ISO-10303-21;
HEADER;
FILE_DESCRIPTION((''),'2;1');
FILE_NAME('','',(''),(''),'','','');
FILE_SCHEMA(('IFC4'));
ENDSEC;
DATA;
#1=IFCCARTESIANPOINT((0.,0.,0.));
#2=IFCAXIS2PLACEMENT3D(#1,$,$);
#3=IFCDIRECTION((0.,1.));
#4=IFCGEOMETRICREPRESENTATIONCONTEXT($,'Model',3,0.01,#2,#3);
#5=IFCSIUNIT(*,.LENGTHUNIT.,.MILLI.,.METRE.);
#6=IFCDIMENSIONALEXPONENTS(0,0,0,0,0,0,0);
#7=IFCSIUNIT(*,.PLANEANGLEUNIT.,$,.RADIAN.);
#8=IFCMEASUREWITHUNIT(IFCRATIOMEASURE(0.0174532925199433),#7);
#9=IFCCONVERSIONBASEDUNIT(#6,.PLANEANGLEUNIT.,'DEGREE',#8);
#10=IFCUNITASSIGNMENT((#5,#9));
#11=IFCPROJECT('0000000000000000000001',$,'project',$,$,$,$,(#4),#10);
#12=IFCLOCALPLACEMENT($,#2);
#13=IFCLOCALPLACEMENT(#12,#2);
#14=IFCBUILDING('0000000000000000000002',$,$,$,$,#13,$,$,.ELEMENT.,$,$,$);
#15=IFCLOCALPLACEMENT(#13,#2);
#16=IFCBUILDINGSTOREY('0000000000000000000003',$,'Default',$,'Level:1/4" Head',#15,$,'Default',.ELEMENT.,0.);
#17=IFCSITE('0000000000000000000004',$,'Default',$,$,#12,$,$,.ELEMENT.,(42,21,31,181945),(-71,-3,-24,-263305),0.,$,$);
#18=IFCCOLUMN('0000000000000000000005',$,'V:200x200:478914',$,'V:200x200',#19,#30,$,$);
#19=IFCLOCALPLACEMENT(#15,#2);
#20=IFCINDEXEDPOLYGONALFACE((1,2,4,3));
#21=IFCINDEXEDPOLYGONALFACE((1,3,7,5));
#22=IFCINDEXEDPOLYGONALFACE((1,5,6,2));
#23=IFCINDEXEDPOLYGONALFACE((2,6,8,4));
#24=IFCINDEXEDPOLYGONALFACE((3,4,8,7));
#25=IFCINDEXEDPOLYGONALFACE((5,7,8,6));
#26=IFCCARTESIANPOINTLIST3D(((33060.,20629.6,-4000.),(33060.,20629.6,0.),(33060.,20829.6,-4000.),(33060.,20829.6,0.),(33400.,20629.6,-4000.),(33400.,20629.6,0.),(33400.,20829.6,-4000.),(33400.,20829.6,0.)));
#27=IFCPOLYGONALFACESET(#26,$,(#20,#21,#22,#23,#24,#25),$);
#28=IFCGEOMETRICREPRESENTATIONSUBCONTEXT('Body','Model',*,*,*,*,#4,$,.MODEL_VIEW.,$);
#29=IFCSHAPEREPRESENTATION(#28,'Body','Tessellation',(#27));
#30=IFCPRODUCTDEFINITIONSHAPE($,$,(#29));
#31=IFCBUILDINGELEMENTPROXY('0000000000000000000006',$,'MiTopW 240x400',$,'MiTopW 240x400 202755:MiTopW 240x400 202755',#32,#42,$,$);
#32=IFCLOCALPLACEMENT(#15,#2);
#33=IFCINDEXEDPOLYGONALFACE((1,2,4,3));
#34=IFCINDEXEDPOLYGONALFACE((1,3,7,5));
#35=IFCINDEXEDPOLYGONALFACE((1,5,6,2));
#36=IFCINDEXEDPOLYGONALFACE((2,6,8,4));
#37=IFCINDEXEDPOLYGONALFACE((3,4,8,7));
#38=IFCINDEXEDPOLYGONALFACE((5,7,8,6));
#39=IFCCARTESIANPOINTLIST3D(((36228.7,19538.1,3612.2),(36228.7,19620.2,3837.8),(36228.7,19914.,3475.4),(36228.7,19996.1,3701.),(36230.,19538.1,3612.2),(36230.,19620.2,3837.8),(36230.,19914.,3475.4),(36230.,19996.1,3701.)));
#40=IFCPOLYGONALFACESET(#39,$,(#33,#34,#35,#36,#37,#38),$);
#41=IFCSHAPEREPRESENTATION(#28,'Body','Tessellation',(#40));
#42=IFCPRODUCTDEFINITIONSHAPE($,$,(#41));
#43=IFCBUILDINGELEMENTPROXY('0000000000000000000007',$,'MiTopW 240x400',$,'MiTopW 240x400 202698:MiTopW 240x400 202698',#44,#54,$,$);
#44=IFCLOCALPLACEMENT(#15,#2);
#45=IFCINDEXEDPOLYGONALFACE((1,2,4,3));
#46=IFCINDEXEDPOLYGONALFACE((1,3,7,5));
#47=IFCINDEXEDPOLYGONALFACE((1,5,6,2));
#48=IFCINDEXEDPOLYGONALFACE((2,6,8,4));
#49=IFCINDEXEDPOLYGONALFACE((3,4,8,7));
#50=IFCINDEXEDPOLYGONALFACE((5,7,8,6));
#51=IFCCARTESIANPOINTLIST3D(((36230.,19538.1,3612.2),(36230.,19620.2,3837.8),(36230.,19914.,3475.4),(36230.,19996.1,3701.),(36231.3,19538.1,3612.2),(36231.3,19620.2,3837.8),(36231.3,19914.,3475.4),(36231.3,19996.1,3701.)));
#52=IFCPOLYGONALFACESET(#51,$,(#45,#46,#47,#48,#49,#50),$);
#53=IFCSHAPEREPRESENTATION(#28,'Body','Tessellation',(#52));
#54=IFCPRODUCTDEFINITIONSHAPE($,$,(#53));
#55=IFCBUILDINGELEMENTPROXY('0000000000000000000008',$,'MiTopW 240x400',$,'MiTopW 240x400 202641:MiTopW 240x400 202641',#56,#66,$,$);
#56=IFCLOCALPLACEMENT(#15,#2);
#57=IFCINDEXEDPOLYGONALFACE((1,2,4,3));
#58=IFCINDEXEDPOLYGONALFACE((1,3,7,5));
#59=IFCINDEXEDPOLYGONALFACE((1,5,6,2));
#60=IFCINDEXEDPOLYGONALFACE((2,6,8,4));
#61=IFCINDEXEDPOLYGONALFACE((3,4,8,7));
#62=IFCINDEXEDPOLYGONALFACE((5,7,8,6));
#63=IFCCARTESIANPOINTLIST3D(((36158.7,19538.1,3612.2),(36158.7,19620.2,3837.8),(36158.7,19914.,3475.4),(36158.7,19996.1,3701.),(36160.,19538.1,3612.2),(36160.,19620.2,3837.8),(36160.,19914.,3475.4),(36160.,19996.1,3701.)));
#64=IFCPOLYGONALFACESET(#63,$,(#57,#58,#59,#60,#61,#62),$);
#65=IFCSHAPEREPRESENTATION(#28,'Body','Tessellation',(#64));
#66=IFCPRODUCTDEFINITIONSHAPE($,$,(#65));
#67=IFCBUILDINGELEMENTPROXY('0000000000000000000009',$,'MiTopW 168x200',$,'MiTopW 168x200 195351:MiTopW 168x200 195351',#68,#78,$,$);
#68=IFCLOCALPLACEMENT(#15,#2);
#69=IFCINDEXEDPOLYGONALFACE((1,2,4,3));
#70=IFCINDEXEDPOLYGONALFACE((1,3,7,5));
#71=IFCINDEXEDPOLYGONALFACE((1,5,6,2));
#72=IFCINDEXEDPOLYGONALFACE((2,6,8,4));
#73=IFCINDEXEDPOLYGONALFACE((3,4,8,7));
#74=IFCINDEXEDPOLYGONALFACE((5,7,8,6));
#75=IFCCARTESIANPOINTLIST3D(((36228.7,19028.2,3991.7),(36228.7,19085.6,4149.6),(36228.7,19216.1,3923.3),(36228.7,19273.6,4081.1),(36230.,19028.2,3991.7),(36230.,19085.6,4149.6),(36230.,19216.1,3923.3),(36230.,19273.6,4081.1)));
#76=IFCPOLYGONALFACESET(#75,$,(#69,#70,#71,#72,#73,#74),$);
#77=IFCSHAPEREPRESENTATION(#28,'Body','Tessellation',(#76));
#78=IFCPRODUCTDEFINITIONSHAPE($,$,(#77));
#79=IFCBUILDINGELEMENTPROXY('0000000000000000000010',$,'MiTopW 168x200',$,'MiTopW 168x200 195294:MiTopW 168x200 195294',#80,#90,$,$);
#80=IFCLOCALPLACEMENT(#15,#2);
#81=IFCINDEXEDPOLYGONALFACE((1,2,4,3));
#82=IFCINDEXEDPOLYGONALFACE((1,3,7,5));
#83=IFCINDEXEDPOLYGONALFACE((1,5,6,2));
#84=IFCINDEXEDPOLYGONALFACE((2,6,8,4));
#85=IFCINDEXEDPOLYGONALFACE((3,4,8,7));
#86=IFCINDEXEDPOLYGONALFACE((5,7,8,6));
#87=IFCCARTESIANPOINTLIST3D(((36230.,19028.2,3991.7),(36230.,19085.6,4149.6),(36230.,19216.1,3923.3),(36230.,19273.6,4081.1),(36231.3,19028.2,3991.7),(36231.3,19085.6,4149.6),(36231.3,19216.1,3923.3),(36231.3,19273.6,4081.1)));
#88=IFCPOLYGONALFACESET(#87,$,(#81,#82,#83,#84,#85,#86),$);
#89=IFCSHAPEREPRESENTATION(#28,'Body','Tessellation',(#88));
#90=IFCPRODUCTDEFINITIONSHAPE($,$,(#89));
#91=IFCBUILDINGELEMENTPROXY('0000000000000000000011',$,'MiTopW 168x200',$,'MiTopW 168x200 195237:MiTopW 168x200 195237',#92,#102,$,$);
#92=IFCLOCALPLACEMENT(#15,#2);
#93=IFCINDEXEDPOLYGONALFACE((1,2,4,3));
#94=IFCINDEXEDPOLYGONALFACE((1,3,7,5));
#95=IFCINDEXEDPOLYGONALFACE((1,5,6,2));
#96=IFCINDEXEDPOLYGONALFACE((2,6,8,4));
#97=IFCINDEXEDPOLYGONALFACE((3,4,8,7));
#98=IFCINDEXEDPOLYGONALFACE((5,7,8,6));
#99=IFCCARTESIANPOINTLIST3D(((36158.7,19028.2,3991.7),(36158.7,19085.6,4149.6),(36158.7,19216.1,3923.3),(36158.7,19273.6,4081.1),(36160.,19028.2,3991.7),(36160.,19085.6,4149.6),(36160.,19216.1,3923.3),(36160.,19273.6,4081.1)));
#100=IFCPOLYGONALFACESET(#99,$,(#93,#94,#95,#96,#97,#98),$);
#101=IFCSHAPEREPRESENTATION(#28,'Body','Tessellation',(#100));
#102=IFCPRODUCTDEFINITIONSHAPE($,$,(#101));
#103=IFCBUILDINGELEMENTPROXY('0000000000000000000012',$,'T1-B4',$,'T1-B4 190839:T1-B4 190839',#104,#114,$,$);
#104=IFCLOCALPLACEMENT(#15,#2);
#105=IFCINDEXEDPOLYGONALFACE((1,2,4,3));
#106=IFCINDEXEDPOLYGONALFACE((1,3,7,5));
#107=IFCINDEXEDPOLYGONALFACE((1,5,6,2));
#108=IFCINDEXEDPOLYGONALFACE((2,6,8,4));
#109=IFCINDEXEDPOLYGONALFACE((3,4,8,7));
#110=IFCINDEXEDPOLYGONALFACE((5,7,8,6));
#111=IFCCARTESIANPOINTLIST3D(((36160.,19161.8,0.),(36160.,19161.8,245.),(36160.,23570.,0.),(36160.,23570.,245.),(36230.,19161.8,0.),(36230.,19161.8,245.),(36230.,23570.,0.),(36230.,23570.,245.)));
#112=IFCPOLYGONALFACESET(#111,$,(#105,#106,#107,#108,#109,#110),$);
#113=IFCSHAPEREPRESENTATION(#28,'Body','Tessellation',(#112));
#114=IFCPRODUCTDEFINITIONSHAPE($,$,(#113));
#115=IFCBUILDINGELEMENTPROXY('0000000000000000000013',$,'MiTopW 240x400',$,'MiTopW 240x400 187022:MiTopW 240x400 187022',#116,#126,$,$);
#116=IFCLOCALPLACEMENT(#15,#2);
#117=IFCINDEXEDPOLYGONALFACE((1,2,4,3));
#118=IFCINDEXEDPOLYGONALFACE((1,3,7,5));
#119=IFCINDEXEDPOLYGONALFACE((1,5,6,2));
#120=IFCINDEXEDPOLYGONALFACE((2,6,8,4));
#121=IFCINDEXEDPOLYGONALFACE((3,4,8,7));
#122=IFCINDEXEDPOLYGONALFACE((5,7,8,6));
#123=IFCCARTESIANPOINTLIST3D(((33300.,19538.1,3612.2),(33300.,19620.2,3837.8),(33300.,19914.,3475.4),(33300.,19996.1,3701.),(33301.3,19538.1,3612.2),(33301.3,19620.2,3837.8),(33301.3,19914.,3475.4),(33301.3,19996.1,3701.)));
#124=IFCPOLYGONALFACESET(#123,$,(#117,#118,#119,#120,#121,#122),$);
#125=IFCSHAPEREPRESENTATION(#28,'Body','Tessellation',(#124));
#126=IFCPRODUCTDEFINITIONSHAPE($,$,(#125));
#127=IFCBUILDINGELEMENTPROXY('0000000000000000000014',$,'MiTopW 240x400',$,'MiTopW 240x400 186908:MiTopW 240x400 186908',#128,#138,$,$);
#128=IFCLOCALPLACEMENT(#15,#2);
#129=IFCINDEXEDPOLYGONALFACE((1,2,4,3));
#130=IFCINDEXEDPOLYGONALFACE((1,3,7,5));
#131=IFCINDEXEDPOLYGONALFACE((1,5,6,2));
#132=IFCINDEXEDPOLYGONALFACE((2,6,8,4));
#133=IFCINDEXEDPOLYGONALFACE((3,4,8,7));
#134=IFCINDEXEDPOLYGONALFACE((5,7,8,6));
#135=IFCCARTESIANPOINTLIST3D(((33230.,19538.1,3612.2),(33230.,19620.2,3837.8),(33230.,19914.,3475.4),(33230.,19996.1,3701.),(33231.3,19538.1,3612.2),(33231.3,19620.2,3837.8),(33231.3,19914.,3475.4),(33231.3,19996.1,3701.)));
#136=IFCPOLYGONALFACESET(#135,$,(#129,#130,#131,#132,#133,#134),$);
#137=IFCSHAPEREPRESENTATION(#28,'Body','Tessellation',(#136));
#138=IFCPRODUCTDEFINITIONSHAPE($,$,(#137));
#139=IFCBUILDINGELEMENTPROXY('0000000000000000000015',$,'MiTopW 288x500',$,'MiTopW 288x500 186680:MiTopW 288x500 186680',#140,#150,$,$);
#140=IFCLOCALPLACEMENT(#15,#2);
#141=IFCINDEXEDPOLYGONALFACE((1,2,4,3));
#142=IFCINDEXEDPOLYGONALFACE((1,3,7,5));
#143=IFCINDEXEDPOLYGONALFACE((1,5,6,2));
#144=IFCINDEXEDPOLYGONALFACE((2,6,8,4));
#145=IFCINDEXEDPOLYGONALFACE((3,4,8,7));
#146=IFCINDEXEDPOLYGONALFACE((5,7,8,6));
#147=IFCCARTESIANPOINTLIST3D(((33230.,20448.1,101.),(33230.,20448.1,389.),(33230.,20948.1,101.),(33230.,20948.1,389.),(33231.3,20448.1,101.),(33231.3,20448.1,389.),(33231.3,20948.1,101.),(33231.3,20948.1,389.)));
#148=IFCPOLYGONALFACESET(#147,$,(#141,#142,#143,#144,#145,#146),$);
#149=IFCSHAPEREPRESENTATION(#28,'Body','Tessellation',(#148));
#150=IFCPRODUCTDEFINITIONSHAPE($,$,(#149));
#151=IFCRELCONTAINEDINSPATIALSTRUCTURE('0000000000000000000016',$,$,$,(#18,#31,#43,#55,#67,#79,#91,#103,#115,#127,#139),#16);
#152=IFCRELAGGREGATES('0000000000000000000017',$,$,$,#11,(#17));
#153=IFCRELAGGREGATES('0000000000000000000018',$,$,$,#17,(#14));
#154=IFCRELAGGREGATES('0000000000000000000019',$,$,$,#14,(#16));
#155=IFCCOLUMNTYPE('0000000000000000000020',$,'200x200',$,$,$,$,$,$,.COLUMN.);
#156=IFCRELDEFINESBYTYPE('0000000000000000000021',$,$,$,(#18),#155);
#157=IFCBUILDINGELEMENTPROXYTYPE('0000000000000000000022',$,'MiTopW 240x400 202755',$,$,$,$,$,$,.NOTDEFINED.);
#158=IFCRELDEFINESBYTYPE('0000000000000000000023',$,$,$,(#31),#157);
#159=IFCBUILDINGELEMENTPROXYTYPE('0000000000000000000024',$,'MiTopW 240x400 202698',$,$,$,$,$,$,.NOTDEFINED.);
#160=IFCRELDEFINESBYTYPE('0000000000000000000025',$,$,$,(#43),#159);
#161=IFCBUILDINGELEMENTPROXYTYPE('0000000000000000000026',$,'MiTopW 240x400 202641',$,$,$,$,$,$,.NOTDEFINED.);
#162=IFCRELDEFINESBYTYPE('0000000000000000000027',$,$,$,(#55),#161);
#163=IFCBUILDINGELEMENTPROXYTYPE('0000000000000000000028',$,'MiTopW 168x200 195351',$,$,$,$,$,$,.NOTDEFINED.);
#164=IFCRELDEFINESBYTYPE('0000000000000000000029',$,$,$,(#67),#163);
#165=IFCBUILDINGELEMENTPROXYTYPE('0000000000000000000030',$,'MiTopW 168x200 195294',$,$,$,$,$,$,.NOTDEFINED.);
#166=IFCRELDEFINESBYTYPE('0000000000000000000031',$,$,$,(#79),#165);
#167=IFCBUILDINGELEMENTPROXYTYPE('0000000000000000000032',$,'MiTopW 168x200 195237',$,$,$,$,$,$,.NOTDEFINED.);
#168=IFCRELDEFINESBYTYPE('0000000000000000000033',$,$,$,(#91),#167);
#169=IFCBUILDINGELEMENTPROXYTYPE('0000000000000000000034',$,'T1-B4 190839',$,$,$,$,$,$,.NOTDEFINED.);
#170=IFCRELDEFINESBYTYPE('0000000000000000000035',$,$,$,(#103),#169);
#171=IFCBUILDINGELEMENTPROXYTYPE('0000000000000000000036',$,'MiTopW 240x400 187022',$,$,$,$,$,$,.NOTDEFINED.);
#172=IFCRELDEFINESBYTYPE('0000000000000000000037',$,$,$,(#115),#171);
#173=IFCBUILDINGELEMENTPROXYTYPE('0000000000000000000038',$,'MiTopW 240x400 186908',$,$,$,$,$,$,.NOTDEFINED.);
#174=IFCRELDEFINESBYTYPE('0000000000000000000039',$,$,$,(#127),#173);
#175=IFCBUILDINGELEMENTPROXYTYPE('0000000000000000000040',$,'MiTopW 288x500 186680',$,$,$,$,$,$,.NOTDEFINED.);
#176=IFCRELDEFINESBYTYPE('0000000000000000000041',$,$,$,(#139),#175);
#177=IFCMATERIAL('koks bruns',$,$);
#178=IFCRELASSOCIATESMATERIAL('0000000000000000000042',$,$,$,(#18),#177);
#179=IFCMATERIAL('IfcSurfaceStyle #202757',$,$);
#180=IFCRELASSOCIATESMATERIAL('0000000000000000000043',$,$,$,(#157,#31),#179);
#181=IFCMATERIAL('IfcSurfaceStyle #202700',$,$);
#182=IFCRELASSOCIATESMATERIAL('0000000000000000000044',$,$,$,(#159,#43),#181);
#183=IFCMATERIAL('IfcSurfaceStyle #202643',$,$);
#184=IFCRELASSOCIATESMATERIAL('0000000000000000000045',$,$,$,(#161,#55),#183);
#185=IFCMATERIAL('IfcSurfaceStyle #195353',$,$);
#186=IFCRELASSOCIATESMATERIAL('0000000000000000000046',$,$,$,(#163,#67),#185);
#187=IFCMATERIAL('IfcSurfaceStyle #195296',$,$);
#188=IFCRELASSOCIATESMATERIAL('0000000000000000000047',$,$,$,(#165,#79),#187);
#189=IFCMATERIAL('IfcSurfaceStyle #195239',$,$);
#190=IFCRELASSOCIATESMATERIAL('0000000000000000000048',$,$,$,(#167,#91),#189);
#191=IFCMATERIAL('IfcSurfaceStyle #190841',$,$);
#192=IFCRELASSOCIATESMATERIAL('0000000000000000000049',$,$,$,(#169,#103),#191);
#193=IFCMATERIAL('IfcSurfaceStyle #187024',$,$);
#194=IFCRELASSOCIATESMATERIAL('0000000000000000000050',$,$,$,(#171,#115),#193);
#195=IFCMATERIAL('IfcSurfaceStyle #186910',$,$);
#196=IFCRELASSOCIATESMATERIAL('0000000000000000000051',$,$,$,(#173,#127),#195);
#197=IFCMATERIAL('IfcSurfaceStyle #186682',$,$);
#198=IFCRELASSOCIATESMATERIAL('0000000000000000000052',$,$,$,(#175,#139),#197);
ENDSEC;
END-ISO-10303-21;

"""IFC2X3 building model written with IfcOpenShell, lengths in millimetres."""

from ifc_helpers import new_model, entity, si_unit, converted_unit, direction, frame, origin, origin_2d_with_axis, place, context, subcontext, project, spatial, polyline, rectangle, outline, extrude, source, transform, mapped, material, type_object, type_shapes, element, save


model = new_model("IFC2X3")

# Units and contexts
model_context = context("Model", 3, precision=0.01, world=origin(), true_north=direction((0.0, 1.0)))
body_context = subcontext(model_context, "Body", "Model", "MODEL_VIEW")
ifc_project = project(units=[si_unit("LENGTHUNIT", "METRE", prefix="MILLI"), converted_unit("PLANEANGLEUNIT", "DEGREE", entity("IfcRatioMeasure", 0.0174532925199433), si_unit("PLANEANGLEUNIT", "RADIAN"), dimensions=[0, 0, 0, 0, 0, 0, 0])], contexts=[model_context])

# Site, building, storey
site_placement = place(None, origin())
site = spatial("IfcSite", under=ifc_project, at=site_placement, Name="Default", CompositionType="ELEMENT", RefLatitude=(42, 21, 31, 181945), RefLongitude=(-71, -3, -24, -263305), RefElevation=0.0)
building_placement = place(site_placement, origin())
building = spatial("IfcBuilding", under=site, at=building_placement, CompositionType="ELEMENT")
storey_placement = place(building_placement, origin())
storey = spatial("IfcBuildingStorey", under=building, at=storey_placement, Name="Default", ObjectType="Level:1/4\" Head", LongName="Default", CompositionType="ELEMENT", Elevation=0.0)

# Column
ifc_material_1 = material(Name="koks bruns")
column_type_1 = type_object("IfcColumnType", Name="200x200", PredefinedType="COLUMN")
shared_shape_1 = source(origin(), body_context, "Body", "SweptSolid", [
    extrude(rectangle(XDim=340.0, YDim=200.0, at=origin_2d_with_axis()), frame((100.0, 280.0, -4000.0), z_axis=(0.0, 0.0, 1.0), x_axis=(0.0, -1.0, 0.0)), (0.0, 0.0, 1.0), 4000.0),
])
type_shapes(column_type_1, [shared_shape_1])
column_placement = place(storey_placement, frame((33510.0, 20629.6, 0.0), z_axis=(0.0, 0.0, 1.0), x_axis=(0.0, 1.0, 0.0)))
element("IfcColumn", 1, at=column_placement, inside=storey, type_object=column_type_1, material=ifc_material_1, Name="V:200x200:478914", ObjectType="V:200x200", context=body_context, shape_type="MappedRepresentation", body=[
    mapped(shared_shape_1, transform((0.0, 0.0, 0.0), scale=1.0)),
])

# Building element proxies
ifc_material_2 = material(Name="IfcSurfaceStyle #202757")
building_element_proxy_type_1 = type_object("IfcBuildingElementProxyType", Name="MiTopW 240x400 202755", PredefinedType="NOTDEFINED", material=ifc_material_2)
shared_shape_2 = source(origin(), body_context, "Body", "SweptSolid", [
    extrude(outline(polyline([(-200.0, -120.0), (200.0, -120.0), (200.0, 120.0), (-200.0, 120.0), (-200.0, -120.0)])), frame((200.0, 120.0, 0.0), z_axis=(0.0, 0.0, 1.0), x_axis=(-1.0, 0.0, 0.0)), (0.0, 0.0, 1.0), 1.3),
])
type_shapes(building_element_proxy_type_1, [shared_shape_2])
proxy_1_placement = place(building_placement, frame((36230.0, 19620.2, 3837.8), z_axis=(-1.0, 0.0, 0.0), x_axis=(0.0, 0.939693, -0.34202)))
element("IfcBuildingElementProxy", 2, at=proxy_1_placement, inside=storey, type_object=building_element_proxy_type_1, material=ifc_material_2, Name="MiTopW 240x400", ObjectType="MiTopW 240x400 202755:MiTopW 240x400 202755", context=body_context, shape_type="MappedRepresentation", body=[
    mapped(shared_shape_2, transform((0.0, 0.0, 0.0), scale=1.0)),
])
ifc_material_3 = material(Name="IfcSurfaceStyle #202700")
building_element_proxy_type_2 = type_object("IfcBuildingElementProxyType", Name="MiTopW 240x400 202698", PredefinedType="NOTDEFINED", material=ifc_material_3)
shared_shape_3 = source(origin(), body_context, "Body", "SweptSolid", [
    extrude(outline(polyline([(-200.0, -120.0), (200.0, -120.0), (200.0, 120.0), (-200.0, 120.0), (-200.0, -120.0)])), frame((200.0, 120.0, 0.0), z_axis=(0.0, 0.0, 1.0), x_axis=(-1.0, 0.0, 0.0)), (0.0, 0.0, 1.0), 1.3),
])
type_shapes(building_element_proxy_type_2, [shared_shape_3])
proxy_2_placement = place(building_placement, frame((36231.3, 19620.2, 3837.8), z_axis=(-1.0, 0.0, 0.0), x_axis=(0.0, 0.939693, -0.34202)))
element("IfcBuildingElementProxy", 3, at=proxy_2_placement, inside=storey, type_object=building_element_proxy_type_2, material=ifc_material_3, Name="MiTopW 240x400", ObjectType="MiTopW 240x400 202698:MiTopW 240x400 202698", context=body_context, shape_type="MappedRepresentation", body=[
    mapped(shared_shape_3, transform((0.0, 0.0, 0.0), scale=1.0)),
])
ifc_material_4 = material(Name="IfcSurfaceStyle #202643")
building_element_proxy_type_3 = type_object("IfcBuildingElementProxyType", Name="MiTopW 240x400 202641", PredefinedType="NOTDEFINED", material=ifc_material_4)
shared_shape_4 = source(origin(), body_context, "Body", "SweptSolid", [
    extrude(outline(polyline([(-200.0, -120.0), (200.0, -120.0), (200.0, 120.0), (-200.0, 120.0), (-200.0, -120.0)])), frame((200.0, 120.0, 0.0), z_axis=(0.0, 0.0, 1.0), x_axis=(-1.0, 0.0, 0.0)), (0.0, 0.0, 1.0), 1.3),
])
type_shapes(building_element_proxy_type_3, [shared_shape_4])
proxy_3_placement = place(building_placement, frame((36160.0, 19620.2, 3837.8), z_axis=(-1.0, 0.0, 0.0), x_axis=(0.0, 0.939693, -0.34202)))
element("IfcBuildingElementProxy", 4, at=proxy_3_placement, inside=storey, type_object=building_element_proxy_type_3, material=ifc_material_4, Name="MiTopW 240x400", ObjectType="MiTopW 240x400 202641:MiTopW 240x400 202641", context=body_context, shape_type="MappedRepresentation", body=[
    mapped(shared_shape_4, transform((0.0, 0.0, 0.0), scale=1.0)),
])
ifc_material_5 = material(Name="IfcSurfaceStyle #195353")
building_element_proxy_type_4 = type_object("IfcBuildingElementProxyType", Name="MiTopW 168x200 195351", PredefinedType="NOTDEFINED", material=ifc_material_5)
shared_shape_5 = source(origin(), body_context, "Body", "SweptSolid", [
    extrude(outline(polyline([(-100.0, -84.0), (100.0, -84.0), (100.0, 84.0), (-100.0, 84.0), (-100.0, -84.0)])), frame((100.0, 84.0, 0.0), z_axis=(0.0, 0.0, 1.0), x_axis=(-1.0, 0.0, 0.0)), (0.0, 0.0, 1.0), 1.3),
])
type_shapes(building_element_proxy_type_4, [shared_shape_5])
proxy_4_placement = place(building_placement, frame((36230.0, 19216.1, 3923.3), z_axis=(-1.0, 0.0, 0.0), x_axis=(0.0, -0.939693, 0.34202)))
element("IfcBuildingElementProxy", 5, at=proxy_4_placement, inside=storey, type_object=building_element_proxy_type_4, material=ifc_material_5, Name="MiTopW 168x200", ObjectType="MiTopW 168x200 195351:MiTopW 168x200 195351", context=body_context, shape_type="MappedRepresentation", body=[
    mapped(shared_shape_5, transform((0.0, 0.0, 0.0), scale=1.0)),
])
ifc_material_6 = material(Name="IfcSurfaceStyle #195296")
building_element_proxy_type_5 = type_object("IfcBuildingElementProxyType", Name="MiTopW 168x200 195294", PredefinedType="NOTDEFINED", material=ifc_material_6)
shared_shape_6 = source(origin(), body_context, "Body", "SweptSolid", [
    extrude(outline(polyline([(-100.0, -84.0), (100.0, -84.0), (100.0, 84.0), (-100.0, 84.0), (-100.0, -84.0)])), frame((100.0, 84.0, 0.0), z_axis=(0.0, 0.0, 1.0), x_axis=(-1.0, 0.0, 0.0)), (0.0, 0.0, 1.0), 1.3),
])
type_shapes(building_element_proxy_type_5, [shared_shape_6])
proxy_5_placement = place(building_placement, frame((36231.3, 19216.1, 3923.3), z_axis=(-1.0, 0.0, 0.0), x_axis=(0.0, -0.939693, 0.34202)))
element("IfcBuildingElementProxy", 6, at=proxy_5_placement, inside=storey, type_object=building_element_proxy_type_5, material=ifc_material_6, Name="MiTopW 168x200", ObjectType="MiTopW 168x200 195294:MiTopW 168x200 195294", context=body_context, shape_type="MappedRepresentation", body=[
    mapped(shared_shape_6, transform((0.0, 0.0, 0.0), scale=1.0)),
])
ifc_material_7 = material(Name="IfcSurfaceStyle #195239")
building_element_proxy_type_6 = type_object("IfcBuildingElementProxyType", Name="MiTopW 168x200 195237", PredefinedType="NOTDEFINED", material=ifc_material_7)
shared_shape_7 = source(origin(), body_context, "Body", "SweptSolid", [
    extrude(outline(polyline([(-100.0, -84.0), (100.0, -84.0), (100.0, 84.0), (-100.0, 84.0), (-100.0, -84.0)])), frame((100.0, 84.0, 0.0), z_axis=(0.0, 0.0, 1.0), x_axis=(-1.0, 0.0, 0.0)), (0.0, 0.0, 1.0), 1.3),
])
type_shapes(building_element_proxy_type_6, [shared_shape_7])
proxy_6_placement = place(building_placement, frame((36160.0, 19216.1, 3923.3), z_axis=(-1.0, 0.0, 0.0), x_axis=(0.0, -0.939693, 0.34202)))
element("IfcBuildingElementProxy", 7, at=proxy_6_placement, inside=storey, type_object=building_element_proxy_type_6, material=ifc_material_7, Name="MiTopW 168x200", ObjectType="MiTopW 168x200 195237:MiTopW 168x200 195237", context=body_context, shape_type="MappedRepresentation", body=[
    mapped(shared_shape_7, transform((0.0, 0.0, 0.0), scale=1.0)),
])
ifc_material_8 = material(Name="IfcSurfaceStyle #190841")
building_element_proxy_type_7 = type_object("IfcBuildingElementProxyType", Name="T1-B4 190839", PredefinedType="NOTDEFINED", material=ifc_material_8)
shared_shape_8 = source(origin(), body_context, "Body", "SweptSolid", [
    extrude(rectangle(XDim=4408.2, YDim=245.0, at=origin_2d_with_axis()), frame((2204.1, 122.5, 0.0), z_axis=(0.0, 0.0, 1.0), x_axis=(-1.0, 0.0, 0.0)), (0.0, 0.0, 1.0), 70.0),
])
type_shapes(building_element_proxy_type_7, [shared_shape_8])
proxy_7_placement = place(building_placement, frame((36230.0, 19161.8, 245.0), z_axis=(-1.0, 0.0, 0.0), x_axis=(0.0, 1.0, 0.0)))
element("IfcBuildingElementProxy", 8, at=proxy_7_placement, inside=storey, type_object=building_element_proxy_type_7, material=ifc_material_8, Name="T1-B4", ObjectType="T1-B4 190839:T1-B4 190839", context=body_context, shape_type="MappedRepresentation", body=[
    mapped(shared_shape_8, transform((0.0, 0.0, 0.0), scale=1.0)),
])
ifc_material_9 = material(Name="IfcSurfaceStyle #187024")
building_element_proxy_type_8 = type_object("IfcBuildingElementProxyType", Name="MiTopW 240x400 187022", PredefinedType="NOTDEFINED", material=ifc_material_9)
shared_shape_9 = source(origin(), body_context, "Body", "SweptSolid", [
    extrude(outline(polyline([(-200.0, -120.0), (200.0, -120.0), (200.0, 120.0), (-200.0, 120.0), (-200.0, -120.0)])), frame((200.0, 120.0, 0.0), z_axis=(0.0, 0.0, 1.0), x_axis=(-1.0, 0.0, 0.0)), (0.0, 0.0, 1.0), 1.3),
])
type_shapes(building_element_proxy_type_8, [shared_shape_9])
proxy_8_placement = place(building_placement, frame((33301.3, 19620.2, 3837.8), z_axis=(-1.0, 0.0, 0.0), x_axis=(0.0, 0.939693, -0.34202)))
element("IfcBuildingElementProxy", 9, at=proxy_8_placement, inside=storey, type_object=building_element_proxy_type_8, material=ifc_material_9, Name="MiTopW 240x400", ObjectType="MiTopW 240x400 187022:MiTopW 240x400 187022", context=body_context, shape_type="MappedRepresentation", body=[
    mapped(shared_shape_9, transform((0.0, 0.0, 0.0), scale=1.0)),
])
ifc_material_10 = material(Name="IfcSurfaceStyle #186910")
building_element_proxy_type_9 = type_object("IfcBuildingElementProxyType", Name="MiTopW 240x400 186908", PredefinedType="NOTDEFINED", material=ifc_material_10)
shared_shape_10 = source(origin(), body_context, "Body", "SweptSolid", [
    extrude(outline(polyline([(-200.0, -120.0), (200.0, -120.0), (200.0, 120.0), (-200.0, 120.0), (-200.0, -120.0)])), frame((200.0, 120.0, 0.0), z_axis=(0.0, 0.0, 1.0), x_axis=(-1.0, 0.0, 0.0)), (0.0, 0.0, 1.0), 1.3),
])
type_shapes(building_element_proxy_type_9, [shared_shape_10])
proxy_9_placement = place(building_placement, frame((33231.3, 19620.2, 3837.8), z_axis=(-1.0, 0.0, 0.0), x_axis=(0.0, 0.939693, -0.34202)))
element("IfcBuildingElementProxy", 10, at=proxy_9_placement, inside=storey, type_object=building_element_proxy_type_9, material=ifc_material_10, Name="MiTopW 240x400", ObjectType="MiTopW 240x400 186908:MiTopW 240x400 186908", context=body_context, shape_type="MappedRepresentation", body=[
    mapped(shared_shape_10, transform((0.0, 0.0, 0.0), scale=1.0)),
])
ifc_material_11 = material(Name="IfcSurfaceStyle #186682")
building_element_proxy_type_10 = type_object("IfcBuildingElementProxyType", Name="MiTopW 288x500 186680", PredefinedType="NOTDEFINED", material=ifc_material_11)
shared_shape_11 = source(origin(), body_context, "Body", "SweptSolid", [
    extrude(rectangle(XDim=500.0, YDim=288.0, at=origin_2d_with_axis()), frame((250.0, 144.0, 0.0), z_axis=(0.0, 0.0, 1.0), x_axis=(-1.0, 0.0, 0.0)), (0.0, 0.0, 1.0), 1.3),
])
type_shapes(building_element_proxy_type_10, [shared_shape_11])
proxy_10_placement = place(building_placement, frame((33231.3, 20948.1, 101.0), z_axis=(-1.0, 0.0, 0.0), x_axis=(0.0, -1.0, 0.0)))
element("IfcBuildingElementProxy", 11, at=proxy_10_placement, inside=storey, type_object=building_element_proxy_type_10, material=ifc_material_11, Name="MiTopW 288x500", ObjectType="MiTopW 288x500 186680:MiTopW 288x500 186680", context=body_context, shape_type="MappedRepresentation", body=[
    mapped(shared_shape_11, transform((0.0, 0.0, 0.0), scale=1.0)),
])

save(model, "model.ifc")
